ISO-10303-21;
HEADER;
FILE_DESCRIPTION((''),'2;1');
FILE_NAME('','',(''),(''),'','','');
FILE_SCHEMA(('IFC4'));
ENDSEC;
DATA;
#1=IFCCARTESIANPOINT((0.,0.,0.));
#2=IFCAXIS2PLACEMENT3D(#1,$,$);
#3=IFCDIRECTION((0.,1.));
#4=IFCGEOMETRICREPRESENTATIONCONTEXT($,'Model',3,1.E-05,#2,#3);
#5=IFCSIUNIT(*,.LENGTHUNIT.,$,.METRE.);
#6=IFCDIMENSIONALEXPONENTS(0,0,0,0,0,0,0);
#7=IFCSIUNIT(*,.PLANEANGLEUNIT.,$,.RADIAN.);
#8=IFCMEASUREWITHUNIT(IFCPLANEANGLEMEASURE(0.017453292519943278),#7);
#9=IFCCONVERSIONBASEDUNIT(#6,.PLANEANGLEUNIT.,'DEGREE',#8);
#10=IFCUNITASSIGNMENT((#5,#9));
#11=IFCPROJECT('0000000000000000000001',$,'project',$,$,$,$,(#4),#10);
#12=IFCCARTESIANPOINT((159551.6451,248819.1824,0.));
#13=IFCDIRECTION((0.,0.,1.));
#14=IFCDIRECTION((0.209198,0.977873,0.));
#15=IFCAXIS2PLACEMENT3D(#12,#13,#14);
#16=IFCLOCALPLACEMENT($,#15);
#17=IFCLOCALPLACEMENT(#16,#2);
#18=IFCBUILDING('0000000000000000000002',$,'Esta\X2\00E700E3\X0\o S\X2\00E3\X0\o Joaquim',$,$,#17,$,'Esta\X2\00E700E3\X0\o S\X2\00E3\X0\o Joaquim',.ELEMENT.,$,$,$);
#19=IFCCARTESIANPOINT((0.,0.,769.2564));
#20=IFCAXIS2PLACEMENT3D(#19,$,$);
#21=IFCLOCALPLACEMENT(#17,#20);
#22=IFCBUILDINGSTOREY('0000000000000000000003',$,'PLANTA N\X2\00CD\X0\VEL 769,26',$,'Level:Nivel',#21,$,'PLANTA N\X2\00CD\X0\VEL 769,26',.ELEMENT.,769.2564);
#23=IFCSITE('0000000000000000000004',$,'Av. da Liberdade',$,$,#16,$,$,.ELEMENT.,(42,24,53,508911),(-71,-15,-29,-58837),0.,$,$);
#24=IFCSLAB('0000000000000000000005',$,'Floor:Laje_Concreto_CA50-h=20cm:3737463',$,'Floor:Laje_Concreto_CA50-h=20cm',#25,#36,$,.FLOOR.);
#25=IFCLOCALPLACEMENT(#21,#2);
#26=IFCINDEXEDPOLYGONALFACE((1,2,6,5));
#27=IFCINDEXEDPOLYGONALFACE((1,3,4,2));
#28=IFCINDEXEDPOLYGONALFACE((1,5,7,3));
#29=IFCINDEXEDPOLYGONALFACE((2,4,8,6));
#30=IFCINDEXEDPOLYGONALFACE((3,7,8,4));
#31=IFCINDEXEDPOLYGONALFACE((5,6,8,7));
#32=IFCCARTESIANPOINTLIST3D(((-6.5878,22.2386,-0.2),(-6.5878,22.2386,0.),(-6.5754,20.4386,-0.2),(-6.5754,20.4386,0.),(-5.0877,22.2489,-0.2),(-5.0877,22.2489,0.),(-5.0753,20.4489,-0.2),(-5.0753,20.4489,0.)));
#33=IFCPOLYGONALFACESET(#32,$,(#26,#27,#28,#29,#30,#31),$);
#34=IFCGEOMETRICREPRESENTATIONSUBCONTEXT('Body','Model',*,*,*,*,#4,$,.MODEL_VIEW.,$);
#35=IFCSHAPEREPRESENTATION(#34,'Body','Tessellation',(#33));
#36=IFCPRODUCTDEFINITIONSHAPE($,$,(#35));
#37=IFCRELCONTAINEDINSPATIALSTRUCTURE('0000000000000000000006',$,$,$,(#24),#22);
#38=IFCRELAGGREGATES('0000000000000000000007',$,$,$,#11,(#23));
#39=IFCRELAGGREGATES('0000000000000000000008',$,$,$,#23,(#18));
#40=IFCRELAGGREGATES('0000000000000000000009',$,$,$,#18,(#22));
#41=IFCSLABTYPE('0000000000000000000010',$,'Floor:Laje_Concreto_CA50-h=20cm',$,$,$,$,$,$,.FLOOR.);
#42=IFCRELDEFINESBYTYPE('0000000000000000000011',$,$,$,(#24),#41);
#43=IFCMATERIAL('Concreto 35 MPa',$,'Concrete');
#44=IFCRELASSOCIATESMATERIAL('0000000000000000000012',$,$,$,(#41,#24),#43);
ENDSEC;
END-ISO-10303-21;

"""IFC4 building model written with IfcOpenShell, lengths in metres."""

from ifc_helpers import new_model, entity, si_unit, converted_unit, direction, frame, origin, place, context, subcontext, project, spatial, indexed_curve, outline, extrude, material, type_object, element, save


model = new_model("IFC4")

# Units and contexts
model_context = context("Model", 3, precision=1e-05, world=origin(), true_north=direction((0.0, 1.0)))
body_context = subcontext(model_context, "Body", "Model", "MODEL_VIEW")
ifc_project = project(units=[si_unit("LENGTHUNIT", "METRE"), converted_unit("PLANEANGLEUNIT", "DEGREE", entity("IfcPlaneAngleMeasure", 0.017453292519943278), si_unit("PLANEANGLEUNIT", "RADIAN"), dimensions=[0, 0, 0, 0, 0, 0, 0])], contexts=[model_context])

# Site, building, storey
site_placement = place(None, frame((159551.6451, 248819.1824, 0.0), z_axis=(0.0, 0.0, 1.0), x_axis=(0.209198, 0.977873, 0.0)))
site = spatial("IfcSite", under=ifc_project, at=site_placement, Name="Av. da Liberdade", CompositionType="ELEMENT", RefLatitude=(42, 24, 53, 508911), RefLongitude=(-71, -15, -29, -58837), RefElevation=0.0)
building_placement = place(site_placement, origin())
building = spatial("IfcBuilding", under=site, at=building_placement, Name="Estação São Joaquim", LongName="Estação São Joaquim", CompositionType="ELEMENT")
storey_placement = place(building_placement, frame((0.0, 0.0, 769.2564)))
storey = spatial("IfcBuildingStorey", under=building, at=storey_placement, Name="PLANTA NÍVEL 769,26", ObjectType="Level:Nivel", LongName="PLANTA NÍVEL 769,26", CompositionType="ELEMENT", Elevation=769.2564)

# Slab
ifc_material = material(Name="Concreto 35 MPa", Category="Concrete")
slab_type = type_object("IfcSlabType", Name="Floor:Laje_Concreto_CA50-h=20cm", PredefinedType="FLOOR", material=ifc_material)
slab_placement = place(storey_placement, origin())
element("IfcSlab", 1, at=slab_placement, inside=storey, type_object=slab_type, material=ifc_material, Name="Floor:Laje_Concreto_CA50-h=20cm:3737463", ObjectType="Floor:Laje_Concreto_CA50-h=20cm", PredefinedType="FLOOR", context=body_context, shape_type="SweptSolid", body=[
    extrude(outline(indexed_curve([(-0.9, -0.7501), (0.9, -0.7501), (0.9, 0.7501), (-0.9, 0.7501), (-0.9, -0.7501)], self_intersect=False)), frame((-5.8316, 21.3437, 0.0), z_axis=(0.0, 0.0, -1.0), x_axis=(0.006868, -0.999976, 0.0)), (0.0, 0.0, 1.0), 0.2),
])

save(model, "model.ifc")
